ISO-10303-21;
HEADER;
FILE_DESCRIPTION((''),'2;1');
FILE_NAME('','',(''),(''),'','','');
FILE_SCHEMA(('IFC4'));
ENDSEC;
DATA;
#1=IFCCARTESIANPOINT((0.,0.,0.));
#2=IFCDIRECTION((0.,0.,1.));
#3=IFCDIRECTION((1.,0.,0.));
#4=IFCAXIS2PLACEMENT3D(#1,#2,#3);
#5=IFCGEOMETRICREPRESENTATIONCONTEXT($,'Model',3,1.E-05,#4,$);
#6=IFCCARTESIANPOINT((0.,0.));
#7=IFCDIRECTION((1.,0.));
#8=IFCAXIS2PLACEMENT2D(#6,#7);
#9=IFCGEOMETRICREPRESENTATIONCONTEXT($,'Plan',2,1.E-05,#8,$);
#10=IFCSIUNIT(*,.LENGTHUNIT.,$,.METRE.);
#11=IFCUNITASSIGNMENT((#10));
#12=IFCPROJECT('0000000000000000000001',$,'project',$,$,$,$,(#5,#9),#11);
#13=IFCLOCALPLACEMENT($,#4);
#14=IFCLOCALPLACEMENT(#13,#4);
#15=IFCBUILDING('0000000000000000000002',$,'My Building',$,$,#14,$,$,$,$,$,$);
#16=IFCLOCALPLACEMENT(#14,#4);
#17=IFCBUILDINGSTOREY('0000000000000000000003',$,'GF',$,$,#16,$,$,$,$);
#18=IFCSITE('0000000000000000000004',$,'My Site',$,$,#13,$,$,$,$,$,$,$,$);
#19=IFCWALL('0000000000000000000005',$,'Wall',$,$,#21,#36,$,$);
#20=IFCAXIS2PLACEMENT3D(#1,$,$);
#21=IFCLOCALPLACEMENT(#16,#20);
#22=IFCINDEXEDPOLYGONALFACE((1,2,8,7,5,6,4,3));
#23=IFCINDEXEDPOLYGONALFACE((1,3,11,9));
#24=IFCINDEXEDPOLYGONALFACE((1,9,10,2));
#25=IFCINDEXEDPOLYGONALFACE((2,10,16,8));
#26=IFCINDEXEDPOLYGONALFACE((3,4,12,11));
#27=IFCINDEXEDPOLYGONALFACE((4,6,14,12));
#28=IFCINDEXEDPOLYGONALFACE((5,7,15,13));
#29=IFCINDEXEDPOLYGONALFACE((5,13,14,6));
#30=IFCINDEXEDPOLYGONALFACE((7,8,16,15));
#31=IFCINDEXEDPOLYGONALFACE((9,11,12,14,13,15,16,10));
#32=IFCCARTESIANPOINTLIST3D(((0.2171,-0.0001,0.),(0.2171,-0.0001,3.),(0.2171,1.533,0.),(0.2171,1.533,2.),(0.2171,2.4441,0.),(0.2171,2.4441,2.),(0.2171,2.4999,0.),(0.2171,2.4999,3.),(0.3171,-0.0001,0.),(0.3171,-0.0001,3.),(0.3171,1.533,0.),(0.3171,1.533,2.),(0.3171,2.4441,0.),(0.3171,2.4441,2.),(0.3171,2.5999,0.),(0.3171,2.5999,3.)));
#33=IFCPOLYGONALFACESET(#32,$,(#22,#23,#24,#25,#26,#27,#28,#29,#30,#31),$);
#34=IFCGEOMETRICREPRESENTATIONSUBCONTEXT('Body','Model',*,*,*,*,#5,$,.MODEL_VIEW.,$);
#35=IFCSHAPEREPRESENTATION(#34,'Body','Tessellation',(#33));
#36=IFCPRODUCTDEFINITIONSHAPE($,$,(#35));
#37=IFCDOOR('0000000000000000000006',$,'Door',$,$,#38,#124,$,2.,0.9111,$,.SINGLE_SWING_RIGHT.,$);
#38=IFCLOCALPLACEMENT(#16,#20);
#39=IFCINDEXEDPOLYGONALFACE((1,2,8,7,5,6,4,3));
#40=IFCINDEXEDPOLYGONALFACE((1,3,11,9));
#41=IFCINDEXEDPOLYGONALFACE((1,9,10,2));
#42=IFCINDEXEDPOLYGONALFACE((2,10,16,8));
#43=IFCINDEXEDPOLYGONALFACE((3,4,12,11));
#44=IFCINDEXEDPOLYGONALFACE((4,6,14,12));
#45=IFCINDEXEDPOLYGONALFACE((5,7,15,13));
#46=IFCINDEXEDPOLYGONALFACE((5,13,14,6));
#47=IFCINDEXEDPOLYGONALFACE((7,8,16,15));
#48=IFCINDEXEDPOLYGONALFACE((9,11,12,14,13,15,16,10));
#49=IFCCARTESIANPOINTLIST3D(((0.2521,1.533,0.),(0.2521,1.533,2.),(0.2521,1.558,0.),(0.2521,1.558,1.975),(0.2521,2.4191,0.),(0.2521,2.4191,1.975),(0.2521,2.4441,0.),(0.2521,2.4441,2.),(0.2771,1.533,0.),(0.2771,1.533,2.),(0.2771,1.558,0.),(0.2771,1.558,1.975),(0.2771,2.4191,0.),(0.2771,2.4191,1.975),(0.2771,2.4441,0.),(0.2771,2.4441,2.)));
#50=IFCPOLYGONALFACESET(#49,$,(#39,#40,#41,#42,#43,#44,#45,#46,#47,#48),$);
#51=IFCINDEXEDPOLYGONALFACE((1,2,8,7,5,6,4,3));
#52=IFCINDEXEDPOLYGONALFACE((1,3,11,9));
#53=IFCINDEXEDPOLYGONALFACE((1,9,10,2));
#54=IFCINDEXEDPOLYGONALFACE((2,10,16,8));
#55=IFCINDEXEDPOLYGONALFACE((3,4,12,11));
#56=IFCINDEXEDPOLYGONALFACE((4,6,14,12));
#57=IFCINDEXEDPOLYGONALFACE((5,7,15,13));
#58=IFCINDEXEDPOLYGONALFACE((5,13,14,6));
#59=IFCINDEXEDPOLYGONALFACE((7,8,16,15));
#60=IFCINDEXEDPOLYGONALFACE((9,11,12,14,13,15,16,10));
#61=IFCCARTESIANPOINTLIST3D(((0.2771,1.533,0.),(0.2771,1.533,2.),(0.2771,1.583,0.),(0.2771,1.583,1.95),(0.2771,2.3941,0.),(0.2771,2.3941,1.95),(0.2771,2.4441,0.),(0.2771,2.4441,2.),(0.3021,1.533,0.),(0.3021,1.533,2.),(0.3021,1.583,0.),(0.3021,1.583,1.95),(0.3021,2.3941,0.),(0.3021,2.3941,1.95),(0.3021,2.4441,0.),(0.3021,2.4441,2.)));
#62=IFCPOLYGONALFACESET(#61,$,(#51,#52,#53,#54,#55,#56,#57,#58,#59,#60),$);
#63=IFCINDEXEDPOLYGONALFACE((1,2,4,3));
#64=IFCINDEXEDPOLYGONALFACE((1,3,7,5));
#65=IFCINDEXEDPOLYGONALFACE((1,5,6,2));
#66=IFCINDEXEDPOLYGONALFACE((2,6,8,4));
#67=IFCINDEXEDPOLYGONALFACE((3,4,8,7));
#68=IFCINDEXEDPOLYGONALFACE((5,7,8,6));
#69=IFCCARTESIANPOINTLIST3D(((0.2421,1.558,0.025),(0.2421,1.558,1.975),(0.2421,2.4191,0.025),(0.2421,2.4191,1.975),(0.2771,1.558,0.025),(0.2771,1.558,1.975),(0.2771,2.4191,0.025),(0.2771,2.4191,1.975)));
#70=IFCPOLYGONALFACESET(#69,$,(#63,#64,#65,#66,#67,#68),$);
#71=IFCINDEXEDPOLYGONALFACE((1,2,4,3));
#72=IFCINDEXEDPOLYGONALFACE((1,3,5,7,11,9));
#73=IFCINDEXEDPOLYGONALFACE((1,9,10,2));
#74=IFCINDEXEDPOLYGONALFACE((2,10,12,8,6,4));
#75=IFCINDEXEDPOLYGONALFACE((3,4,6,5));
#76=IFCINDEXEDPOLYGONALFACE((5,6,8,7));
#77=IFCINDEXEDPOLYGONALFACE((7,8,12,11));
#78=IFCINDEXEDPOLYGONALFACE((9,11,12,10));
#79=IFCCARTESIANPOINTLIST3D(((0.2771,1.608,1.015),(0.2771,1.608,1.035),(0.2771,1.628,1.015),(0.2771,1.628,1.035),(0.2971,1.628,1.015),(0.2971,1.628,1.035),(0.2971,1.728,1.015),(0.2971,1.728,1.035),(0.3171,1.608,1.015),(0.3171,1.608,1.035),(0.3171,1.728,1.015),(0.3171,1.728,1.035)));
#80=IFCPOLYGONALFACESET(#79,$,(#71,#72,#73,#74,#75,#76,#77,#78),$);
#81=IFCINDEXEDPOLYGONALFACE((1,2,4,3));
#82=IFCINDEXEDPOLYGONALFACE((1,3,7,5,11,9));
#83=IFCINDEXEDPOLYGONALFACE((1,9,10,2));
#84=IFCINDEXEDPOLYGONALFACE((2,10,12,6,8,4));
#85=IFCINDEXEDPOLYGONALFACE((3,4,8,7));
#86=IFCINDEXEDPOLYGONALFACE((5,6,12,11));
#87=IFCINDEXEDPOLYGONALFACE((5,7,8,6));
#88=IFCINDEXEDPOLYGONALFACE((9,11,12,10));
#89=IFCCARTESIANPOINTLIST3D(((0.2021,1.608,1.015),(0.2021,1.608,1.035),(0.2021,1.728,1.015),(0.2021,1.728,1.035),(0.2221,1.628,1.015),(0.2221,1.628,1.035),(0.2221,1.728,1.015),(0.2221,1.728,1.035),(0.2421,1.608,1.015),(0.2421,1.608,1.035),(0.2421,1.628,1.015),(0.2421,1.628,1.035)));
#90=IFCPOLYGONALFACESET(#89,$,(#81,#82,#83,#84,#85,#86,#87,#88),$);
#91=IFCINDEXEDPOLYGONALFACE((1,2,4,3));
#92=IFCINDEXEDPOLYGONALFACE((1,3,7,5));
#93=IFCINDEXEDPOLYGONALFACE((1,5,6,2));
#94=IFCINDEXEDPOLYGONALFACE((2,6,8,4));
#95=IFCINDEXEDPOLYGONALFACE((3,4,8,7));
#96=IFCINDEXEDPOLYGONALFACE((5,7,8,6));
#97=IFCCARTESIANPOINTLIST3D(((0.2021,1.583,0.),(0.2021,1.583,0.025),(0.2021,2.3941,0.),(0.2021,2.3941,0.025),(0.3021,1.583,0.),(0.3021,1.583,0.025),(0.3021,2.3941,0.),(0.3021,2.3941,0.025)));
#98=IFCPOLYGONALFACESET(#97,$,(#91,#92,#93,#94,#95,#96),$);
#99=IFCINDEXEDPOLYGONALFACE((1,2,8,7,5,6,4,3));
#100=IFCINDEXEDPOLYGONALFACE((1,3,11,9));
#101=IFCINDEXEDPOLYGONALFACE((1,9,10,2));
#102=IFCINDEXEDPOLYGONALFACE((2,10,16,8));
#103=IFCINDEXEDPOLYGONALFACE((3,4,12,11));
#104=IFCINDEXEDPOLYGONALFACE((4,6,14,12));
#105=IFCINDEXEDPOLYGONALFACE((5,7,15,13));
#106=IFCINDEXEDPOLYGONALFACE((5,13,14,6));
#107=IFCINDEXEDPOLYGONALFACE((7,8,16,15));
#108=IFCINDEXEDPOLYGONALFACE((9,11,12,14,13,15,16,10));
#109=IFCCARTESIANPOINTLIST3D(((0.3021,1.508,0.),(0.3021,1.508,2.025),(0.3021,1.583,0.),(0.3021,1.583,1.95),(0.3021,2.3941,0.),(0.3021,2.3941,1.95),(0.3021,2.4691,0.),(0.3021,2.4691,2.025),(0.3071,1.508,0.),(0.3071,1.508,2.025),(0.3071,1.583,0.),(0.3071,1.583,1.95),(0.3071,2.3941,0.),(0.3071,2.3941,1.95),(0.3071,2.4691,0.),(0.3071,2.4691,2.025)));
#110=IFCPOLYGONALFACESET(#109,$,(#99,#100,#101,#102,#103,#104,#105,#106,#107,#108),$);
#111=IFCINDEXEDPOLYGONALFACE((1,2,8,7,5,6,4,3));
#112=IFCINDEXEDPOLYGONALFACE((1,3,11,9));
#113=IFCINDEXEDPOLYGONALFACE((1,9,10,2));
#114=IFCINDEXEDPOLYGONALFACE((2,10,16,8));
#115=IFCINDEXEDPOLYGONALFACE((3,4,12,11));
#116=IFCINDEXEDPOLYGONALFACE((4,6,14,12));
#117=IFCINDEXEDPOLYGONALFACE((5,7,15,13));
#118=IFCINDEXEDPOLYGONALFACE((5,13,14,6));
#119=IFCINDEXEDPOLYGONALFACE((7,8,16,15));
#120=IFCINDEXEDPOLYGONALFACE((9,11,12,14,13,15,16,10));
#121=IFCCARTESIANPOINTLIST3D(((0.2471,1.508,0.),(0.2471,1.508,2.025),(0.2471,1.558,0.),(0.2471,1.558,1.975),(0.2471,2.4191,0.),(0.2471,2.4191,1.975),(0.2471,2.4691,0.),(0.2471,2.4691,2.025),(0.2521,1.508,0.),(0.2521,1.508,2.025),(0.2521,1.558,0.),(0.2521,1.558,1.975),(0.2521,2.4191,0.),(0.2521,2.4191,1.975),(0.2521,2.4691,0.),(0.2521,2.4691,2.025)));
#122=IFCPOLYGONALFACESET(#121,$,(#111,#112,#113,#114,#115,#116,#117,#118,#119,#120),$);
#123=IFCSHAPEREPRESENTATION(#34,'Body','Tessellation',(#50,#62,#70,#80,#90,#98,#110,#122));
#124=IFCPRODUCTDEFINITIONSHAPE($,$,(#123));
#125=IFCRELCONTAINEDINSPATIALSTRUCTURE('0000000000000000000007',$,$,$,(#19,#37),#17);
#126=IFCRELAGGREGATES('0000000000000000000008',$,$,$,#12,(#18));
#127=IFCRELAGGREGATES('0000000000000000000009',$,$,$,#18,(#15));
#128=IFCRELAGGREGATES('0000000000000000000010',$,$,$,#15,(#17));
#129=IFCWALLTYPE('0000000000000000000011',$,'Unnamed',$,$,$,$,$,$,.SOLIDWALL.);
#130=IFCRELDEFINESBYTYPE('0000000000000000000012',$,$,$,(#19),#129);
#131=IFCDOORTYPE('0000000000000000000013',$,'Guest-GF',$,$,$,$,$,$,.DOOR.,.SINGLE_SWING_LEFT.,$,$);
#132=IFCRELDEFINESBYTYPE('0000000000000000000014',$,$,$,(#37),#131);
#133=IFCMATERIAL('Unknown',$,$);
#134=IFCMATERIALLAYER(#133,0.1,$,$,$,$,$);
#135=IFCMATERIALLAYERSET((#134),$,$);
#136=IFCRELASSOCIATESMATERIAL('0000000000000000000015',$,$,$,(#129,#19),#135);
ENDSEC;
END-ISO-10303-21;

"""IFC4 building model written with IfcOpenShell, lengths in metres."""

from ifc_helpers import new_model, entity, si_unit, frame, origin_with_axes, origin_2d_with_axis, place, context, subcontext, project, spatial, line, indexed_curve, outline, extrude, shape, source, transform, mapped, material, layer, layer_set, layer_usage, type_object, type_shapes, element, fill, save


model = new_model("IFC4")

# Units and contexts
model_context = context("Model", 3, precision=1e-05, world=origin_with_axes())
plan_context = context("Plan", 2, precision=1e-05, world=origin_2d_with_axis())
body_context_1 = subcontext(model_context, "Body", "Model", "MODEL_VIEW")
body_context_2 = subcontext(plan_context, "Body", "Plan", "PLAN_VIEW")
ifc_project = project(units=[si_unit("LENGTHUNIT", "METRE")], contexts=[model_context, plan_context])

# Site, building, storey
site_placement = place(None, origin_with_axes())
site = spatial("IfcSite", under=ifc_project, at=site_placement, Name="My Site")
building_placement = place(site_placement, origin_with_axes())
building = spatial("IfcBuilding", under=site, at=building_placement, Name="My Building")
storey_placement = place(building_placement, origin_with_axes())
storey = spatial("IfcBuildingStorey", under=building, at=storey_placement, Name="GF")

# Shared definitions
ifc_material = material(Name="Unknown")

# Shared definitions
ifc_layer_1 = layer(ifc_material, 0.1)
ifc_layer_set_1 = layer_set([ifc_layer_1])
wall_type = type_object("IfcWallType", Name="Unnamed", PredefinedType="SOLIDWALL", material=ifc_layer_set_1)

# Wall, opening, door
ifc_layer_usage_1 = layer_usage(ifc_layer_set_1, "AXIS2", "POSITIVE", 0.0)
wall_1_placement = place(storey_placement, frame((0.3171, -0.0001, 0.0), z_axis=(0.0, 0.0, 1.0), x_axis=(0.0, 1.0, 0.0)))
wall_1 = element("IfcWall", 1, at=wall_1_placement, inside=storey, type_object=wall_type, material=ifc_layer_usage_1, Name="Wall", context=body_context_1, shape_type="SweptSolid", body=[
    extrude(outline(indexed_curve([(0.0, 0.0), (0.0, 0.1), (2.5, 0.1), (2.6, 0.0)], segments=[line(1, 2, 3, 4, 1)])), origin_with_axes(), (0.0, 0.0, 1.0), 3.0),
])
shared_shape_1 = source(origin_with_axes(), body_context_1, "Body", "SweptSolid", [
    extrude(outline(indexed_curve([(0.0, 0.0), (0.9111, 0.0), (0.9111, 2.0), (0.0, 2.0)], segments=[line(1, 2, 3, 4, 1)])), frame((0.0, -0.6, 0.0), z_axis=(0.0, -1.0, 0.0), x_axis=(1.0, 0.0, 0.0)), (0.0, 0.0, -1.0), 1.2),
])
opening_1_placement = place(wall_1_placement, frame((1.5331, 0.015, 0.0), z_axis=(0.0, 0.0, 1.0), x_axis=(1.0, 0.0, 0.0)))
opening_1 = element("IfcOpeningElement", 2, at=opening_1_placement, cuts=wall_1, PredefinedType="OPENING", context=body_context_1, shape_type="MappedRepresentation", body=[
    mapped(shared_shape_1, transform((0.0, 0.0, 0.0), x_axis=(1.0, 0.0, 0.0), y_axis=(0.0, 1.0, 0.0), z_axis=(0.0, 0.0, 1.0), scale=1.0)),
])
door_type_1 = type_object("IfcDoorType", Name="Guest-GF", OperationType="SINGLE_SWING_LEFT", PredefinedType="DOOR")
shared_shape_2 = source(origin_with_axes(), body_context_1, "Body", "SweptSolid", [
    extrude(outline(indexed_curve([(0.0, 0.0), (0.0, 2.0), (0.9111, 2.0), (0.9111, 0.0), (0.8861, 0.0), (0.8861, 1.975), (0.025, 1.975), (0.025, 0.0)], segments=[line(1, 2, 3, 4, 5, 6, 7, 8, 1)])), frame((0.0, 0.025, 0.0), z_axis=(0.0, -1.0, 0.0), x_axis=(1.0, 0.0, 0.0)), (0.0, 0.0, -1.0), 0.025),
    extrude(outline(indexed_curve([(0.0, 0.0), (0.0, 2.0), (0.9111, 2.0), (0.9111, 0.0), (0.8611, 0.0), (0.8611, 1.95), (0.05, 1.95), (0.05, 0.0)], segments=[line(1, 2, 3, 4, 5, 6, 7, 8, 1)])), frame((0.0, 0.0, 0.0), z_axis=(0.0, -1.0, 0.0), x_axis=(1.0, 0.0, 0.0)), (0.0, 0.0, -1.0), 0.025),
    extrude(outline(indexed_curve([(0.0, 0.0), (0.8611, 0.0), (0.8611, 0.035), (0.0, 0.035)], segments=[line(1, 2, 3, 4, 1)])), frame((0.025, 0.025, 0.025), z_axis=(0.0, 0.0, 1.0), x_axis=(1.0, 0.0, 0.0)), (0.0, 0.0, 1.0), 1.95),
    extrude(outline(indexed_curve([(0.0, 0.0), (0.0, -0.04), (0.12, -0.04), (0.12, -0.02), (0.02, -0.02), (0.02, 0.0)], segments=[line(1, 2, 3, 4, 5, 6, 1)])), frame((0.075, 0.025, 1.015), z_axis=(0.0, 0.0, 1.0), x_axis=(1.0, 0.0, 0.0)), (0.0, 0.0, 1.0), 0.02),
    extrude(outline(indexed_curve([(0.0, 0.0), (0.0, 0.04), (0.12, 0.04), (0.12, 0.02), (0.02, 0.02), (0.02, 0.0)], segments=[line(1, 2, 3, 4, 5, 6, 1)])), frame((0.075, 0.06, 1.015), z_axis=(0.0, 0.0, 1.0), x_axis=(1.0, 0.0, 0.0)), (0.0, 0.0, 1.0), 0.02),
    extrude(outline(indexed_curve([(0.0, 0.0), (0.8111, 0.0), (0.8111, 0.1), (0.0, 0.1)], segments=[line(1, 2, 3, 4, 1)])), frame((0.05, 0.0, 0.0), z_axis=(0.0, 0.0, 1.0), x_axis=(1.0, 0.0, 0.0)), (0.0, 0.0, 1.0), 0.025),
    extrude(outline(indexed_curve([(0.0, 0.0), (0.0, 2.025), (0.9611, 2.025), (0.9611, 0.0), (0.8861, 0.0), (0.8861, 1.95), (0.075, 1.95), (0.075, 0.0)], segments=[line(1, 2, 3, 4, 5, 6, 7, 8, 1)])), frame((-0.025, -0.005, 0.0), z_axis=(0.0, -1.0, 0.0), x_axis=(1.0, 0.0, 0.0)), (0.0, 0.0, -1.0), 0.005),
    extrude(outline(indexed_curve([(0.0, 0.0), (0.0, 2.025), (0.9611, 2.025), (0.9611, 0.0), (0.9111, 0.0), (0.9111, 1.975), (0.05, 1.975), (0.05, 0.0)], segments=[line(1, 2, 3, 4, 5, 6, 7, 8, 1)])), frame((-0.025, 0.05, 0.0), z_axis=(0.0, -1.0, 0.0), x_axis=(1.0, 0.0, 0.0)), (0.0, 0.0, -1.0), 0.005),
])
shared_shape_3 = source(origin_with_axes(), body_context_2, "Body", "Curve2D", [
    entity("IfcIndexedPolyCurve", entity("IfcCartesianPointList2D", [[0.0, 0.0], [0.0, 0.05], [0.025, 0.05], [0.025, 0.025], [0.05, 0.025], [0.05, 0.0]]), [entity("IfcLineIndex", [1, 2, 3, 4, 5, 6, 1])]),
    entity("IfcIndexedPolyCurve", entity("IfcCartesianPointList2D", [[0.9111, 0.0], [0.9111, 0.05], [0.8861, 0.05], [0.8861, 0.025], [0.8611, 0.025], [0.8611, 0.0]]), [entity("IfcLineIndex", [1, 2, 3, 4, 5, 6, 1])]),
    entity("IfcTrimmedCurve", entity("IfcEllipse", entity("IfcAxis2Placement2D", entity("IfcCartesianPoint", [0.8511, 0.05]), entity("IfcDirection", [1.0, 0.0])), 0.8261, 0.8611), [entity("IfcCartesianPoint", [0.8511, 0.9111])], [entity("IfcCartesianPoint", [0.025, 0.05])], True, "CARTESIAN"),
    entity("IfcIndexedPolyCurve", entity("IfcCartesianPointList2D", [[0.8861, 0.05], [0.8511, 0.05], [0.8511, 0.9111], [0.8861, 0.9111]]), [entity("IfcLineIndex", [1, 2, 3, 4, 1])]),
])
type_shapes(door_type_1, [shared_shape_2, shared_shape_3])
door_1_placement = place(opening_1_placement, frame((0.0, 0.0, 0.0), z_axis=(0.0, 0.0, 1.0), x_axis=(1.0, 0.0, 0.0)))
door_1 = element("IfcDoor", 3, at=door_1_placement, inside=storey, type_object=door_type_1, Name="Door", OperationType="SINGLE_SWING_RIGHT", OverallHeight=2.0, OverallWidth=0.9111, shapes=[
    shape(body_context_1, "Body", "MappedRepresentation", [mapped(shared_shape_2, transform((0.0, 0.0, 0.0), x_axis=(1.0, 0.0, 0.0), y_axis=(0.0, 1.0, 0.0), z_axis=(0.0, 0.0, 1.0), scale=1.0))]),
    shape(body_context_2, "Body", "MappedRepresentation", [mapped(shared_shape_3, transform((0.0, 0.0, 0.0), x_axis=(1.0, 0.0, 0.0), y_axis=(0.0, 1.0, 0.0), z_axis=(0.0, 0.0, 1.0), scale=1.0))]),
])
fill(opening_1, door_1)

save(model, "model.ifc")
